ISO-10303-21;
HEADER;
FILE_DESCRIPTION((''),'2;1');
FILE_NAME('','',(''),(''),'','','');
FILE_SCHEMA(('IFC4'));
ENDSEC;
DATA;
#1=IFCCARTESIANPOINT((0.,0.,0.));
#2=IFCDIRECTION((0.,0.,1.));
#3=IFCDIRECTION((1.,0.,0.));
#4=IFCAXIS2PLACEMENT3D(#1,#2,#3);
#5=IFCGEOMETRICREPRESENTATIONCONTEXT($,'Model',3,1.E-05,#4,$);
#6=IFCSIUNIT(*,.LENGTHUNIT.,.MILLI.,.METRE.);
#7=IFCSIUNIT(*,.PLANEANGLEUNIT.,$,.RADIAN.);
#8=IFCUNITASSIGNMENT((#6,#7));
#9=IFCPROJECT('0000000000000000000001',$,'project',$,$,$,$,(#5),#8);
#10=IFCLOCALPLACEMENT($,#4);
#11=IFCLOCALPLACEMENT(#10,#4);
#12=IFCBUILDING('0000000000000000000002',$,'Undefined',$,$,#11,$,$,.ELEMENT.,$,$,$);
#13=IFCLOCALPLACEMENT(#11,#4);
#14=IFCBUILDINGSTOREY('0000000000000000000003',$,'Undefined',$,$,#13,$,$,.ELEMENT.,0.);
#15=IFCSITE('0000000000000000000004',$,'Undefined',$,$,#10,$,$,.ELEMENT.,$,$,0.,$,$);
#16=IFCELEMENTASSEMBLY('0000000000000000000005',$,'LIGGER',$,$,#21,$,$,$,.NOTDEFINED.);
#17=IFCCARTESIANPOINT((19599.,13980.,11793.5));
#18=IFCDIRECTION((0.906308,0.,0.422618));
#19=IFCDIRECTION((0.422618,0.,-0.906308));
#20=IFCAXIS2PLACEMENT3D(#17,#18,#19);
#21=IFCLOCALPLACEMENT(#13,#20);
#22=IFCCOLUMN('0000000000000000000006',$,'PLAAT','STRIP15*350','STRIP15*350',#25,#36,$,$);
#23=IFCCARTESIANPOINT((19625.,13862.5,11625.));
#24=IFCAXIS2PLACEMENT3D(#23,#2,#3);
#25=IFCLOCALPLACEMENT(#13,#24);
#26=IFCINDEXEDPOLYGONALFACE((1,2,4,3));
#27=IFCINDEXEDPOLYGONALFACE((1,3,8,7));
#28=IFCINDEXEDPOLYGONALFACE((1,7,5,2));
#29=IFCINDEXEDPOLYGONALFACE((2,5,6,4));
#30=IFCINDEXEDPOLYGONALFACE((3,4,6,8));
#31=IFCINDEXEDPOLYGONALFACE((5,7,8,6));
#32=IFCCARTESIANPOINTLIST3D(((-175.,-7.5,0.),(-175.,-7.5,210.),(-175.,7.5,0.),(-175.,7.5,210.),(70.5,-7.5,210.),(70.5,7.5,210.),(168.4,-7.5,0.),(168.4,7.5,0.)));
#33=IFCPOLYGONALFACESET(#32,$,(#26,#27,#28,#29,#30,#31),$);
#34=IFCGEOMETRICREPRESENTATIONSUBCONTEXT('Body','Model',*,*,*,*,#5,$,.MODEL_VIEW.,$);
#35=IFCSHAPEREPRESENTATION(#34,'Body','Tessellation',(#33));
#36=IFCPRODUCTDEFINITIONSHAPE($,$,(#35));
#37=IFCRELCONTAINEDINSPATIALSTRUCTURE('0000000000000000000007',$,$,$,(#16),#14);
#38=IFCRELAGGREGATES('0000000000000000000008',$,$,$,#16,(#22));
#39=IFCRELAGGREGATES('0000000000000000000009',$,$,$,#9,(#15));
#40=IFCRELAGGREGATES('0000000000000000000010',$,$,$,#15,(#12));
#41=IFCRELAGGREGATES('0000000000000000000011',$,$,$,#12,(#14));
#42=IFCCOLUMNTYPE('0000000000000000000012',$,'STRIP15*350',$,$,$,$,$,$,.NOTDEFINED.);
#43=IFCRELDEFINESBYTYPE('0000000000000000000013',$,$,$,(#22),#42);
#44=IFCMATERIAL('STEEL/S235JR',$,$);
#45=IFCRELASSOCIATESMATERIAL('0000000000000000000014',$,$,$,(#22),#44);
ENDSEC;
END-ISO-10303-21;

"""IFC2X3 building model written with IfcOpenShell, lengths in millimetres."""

from ifc_helpers import new_model, si_unit, frame, origin_with_axes, origin_2d_with_axis, place, context, subcontext, project, spatial, rectangle, extrude, clip, halfspace, material, type_object, element, aggregate, save


model = new_model("IFC2X3")

# Units and contexts
model_context = context("Model", 3, precision=1e-05, world=origin_with_axes())
body_context = subcontext(model_context, "Body", "Model", "MODEL_VIEW")
ifc_project = project(units=[si_unit("LENGTHUNIT", "METRE", prefix="MILLI"), si_unit("PLANEANGLEUNIT", "RADIAN")], contexts=[model_context])

# Site, building, storey
site_placement = place(None, origin_with_axes())
site = spatial("IfcSite", under=ifc_project, at=site_placement, Name="Undefined", CompositionType="ELEMENT", RefElevation=0.0)
building_placement = place(site_placement, origin_with_axes())
building = spatial("IfcBuilding", under=site, at=building_placement, Name="Undefined", CompositionType="ELEMENT")
storey_placement = place(building_placement, origin_with_axes())
storey = spatial("IfcBuildingStorey", under=building, at=storey_placement, Name="Undefined", CompositionType="ELEMENT", Elevation=0.0)

# Shared definitions
ifc_material = material(Name="STEEL/S235JR")

# Element assembly, column
assembly_1_placement = place(storey_placement, frame((19599.0, 13980.0, 11793.5), z_axis=(0.906308, 0.0, 0.422618), x_axis=(0.422618, 0.0, -0.906308)))
assembly_1 = element("IfcElementAssembly", 1, at=assembly_1_placement, inside=storey, Name="LIGGER", PredefinedType="NOTDEFINED")
column_type_1 = type_object("IfcColumnType", Name="STRIP15*350", PredefinedType="NOTDEFINED")
column_1_placement = place(storey_placement, frame((19625.0, 13862.5, 11625.0), z_axis=(0.0, 0.0, 1.0), x_axis=(1.0, 0.0, 0.0)))
column_1 = element("IfcColumn", 2, at=column_1_placement, type_object=column_type_1, material=ifc_material, Name="PLAAT", Description="STRIP15*350", ObjectType="STRIP15*350", context=body_context, shape_type="Clipping", body=[
    clip(extrude(rectangle(XDim=15.0, YDim=350.0, at=origin_2d_with_axis()), frame((0.0, 0.0, 210.0), z_axis=(0.0, 0.0, -1.0), x_axis=(0.0, -1.0, 0.0)), (0.0, 0.0, 1.0), 210.0), halfspace(frame((175.0, -7.5, -14.2), z_axis=(0.906308, 0.0, 0.422618), x_axis=(-0.422618, 0.0, 0.906308)), False)),
])

aggregate(assembly_1, [column_1])

save(model, "model.ifc")
